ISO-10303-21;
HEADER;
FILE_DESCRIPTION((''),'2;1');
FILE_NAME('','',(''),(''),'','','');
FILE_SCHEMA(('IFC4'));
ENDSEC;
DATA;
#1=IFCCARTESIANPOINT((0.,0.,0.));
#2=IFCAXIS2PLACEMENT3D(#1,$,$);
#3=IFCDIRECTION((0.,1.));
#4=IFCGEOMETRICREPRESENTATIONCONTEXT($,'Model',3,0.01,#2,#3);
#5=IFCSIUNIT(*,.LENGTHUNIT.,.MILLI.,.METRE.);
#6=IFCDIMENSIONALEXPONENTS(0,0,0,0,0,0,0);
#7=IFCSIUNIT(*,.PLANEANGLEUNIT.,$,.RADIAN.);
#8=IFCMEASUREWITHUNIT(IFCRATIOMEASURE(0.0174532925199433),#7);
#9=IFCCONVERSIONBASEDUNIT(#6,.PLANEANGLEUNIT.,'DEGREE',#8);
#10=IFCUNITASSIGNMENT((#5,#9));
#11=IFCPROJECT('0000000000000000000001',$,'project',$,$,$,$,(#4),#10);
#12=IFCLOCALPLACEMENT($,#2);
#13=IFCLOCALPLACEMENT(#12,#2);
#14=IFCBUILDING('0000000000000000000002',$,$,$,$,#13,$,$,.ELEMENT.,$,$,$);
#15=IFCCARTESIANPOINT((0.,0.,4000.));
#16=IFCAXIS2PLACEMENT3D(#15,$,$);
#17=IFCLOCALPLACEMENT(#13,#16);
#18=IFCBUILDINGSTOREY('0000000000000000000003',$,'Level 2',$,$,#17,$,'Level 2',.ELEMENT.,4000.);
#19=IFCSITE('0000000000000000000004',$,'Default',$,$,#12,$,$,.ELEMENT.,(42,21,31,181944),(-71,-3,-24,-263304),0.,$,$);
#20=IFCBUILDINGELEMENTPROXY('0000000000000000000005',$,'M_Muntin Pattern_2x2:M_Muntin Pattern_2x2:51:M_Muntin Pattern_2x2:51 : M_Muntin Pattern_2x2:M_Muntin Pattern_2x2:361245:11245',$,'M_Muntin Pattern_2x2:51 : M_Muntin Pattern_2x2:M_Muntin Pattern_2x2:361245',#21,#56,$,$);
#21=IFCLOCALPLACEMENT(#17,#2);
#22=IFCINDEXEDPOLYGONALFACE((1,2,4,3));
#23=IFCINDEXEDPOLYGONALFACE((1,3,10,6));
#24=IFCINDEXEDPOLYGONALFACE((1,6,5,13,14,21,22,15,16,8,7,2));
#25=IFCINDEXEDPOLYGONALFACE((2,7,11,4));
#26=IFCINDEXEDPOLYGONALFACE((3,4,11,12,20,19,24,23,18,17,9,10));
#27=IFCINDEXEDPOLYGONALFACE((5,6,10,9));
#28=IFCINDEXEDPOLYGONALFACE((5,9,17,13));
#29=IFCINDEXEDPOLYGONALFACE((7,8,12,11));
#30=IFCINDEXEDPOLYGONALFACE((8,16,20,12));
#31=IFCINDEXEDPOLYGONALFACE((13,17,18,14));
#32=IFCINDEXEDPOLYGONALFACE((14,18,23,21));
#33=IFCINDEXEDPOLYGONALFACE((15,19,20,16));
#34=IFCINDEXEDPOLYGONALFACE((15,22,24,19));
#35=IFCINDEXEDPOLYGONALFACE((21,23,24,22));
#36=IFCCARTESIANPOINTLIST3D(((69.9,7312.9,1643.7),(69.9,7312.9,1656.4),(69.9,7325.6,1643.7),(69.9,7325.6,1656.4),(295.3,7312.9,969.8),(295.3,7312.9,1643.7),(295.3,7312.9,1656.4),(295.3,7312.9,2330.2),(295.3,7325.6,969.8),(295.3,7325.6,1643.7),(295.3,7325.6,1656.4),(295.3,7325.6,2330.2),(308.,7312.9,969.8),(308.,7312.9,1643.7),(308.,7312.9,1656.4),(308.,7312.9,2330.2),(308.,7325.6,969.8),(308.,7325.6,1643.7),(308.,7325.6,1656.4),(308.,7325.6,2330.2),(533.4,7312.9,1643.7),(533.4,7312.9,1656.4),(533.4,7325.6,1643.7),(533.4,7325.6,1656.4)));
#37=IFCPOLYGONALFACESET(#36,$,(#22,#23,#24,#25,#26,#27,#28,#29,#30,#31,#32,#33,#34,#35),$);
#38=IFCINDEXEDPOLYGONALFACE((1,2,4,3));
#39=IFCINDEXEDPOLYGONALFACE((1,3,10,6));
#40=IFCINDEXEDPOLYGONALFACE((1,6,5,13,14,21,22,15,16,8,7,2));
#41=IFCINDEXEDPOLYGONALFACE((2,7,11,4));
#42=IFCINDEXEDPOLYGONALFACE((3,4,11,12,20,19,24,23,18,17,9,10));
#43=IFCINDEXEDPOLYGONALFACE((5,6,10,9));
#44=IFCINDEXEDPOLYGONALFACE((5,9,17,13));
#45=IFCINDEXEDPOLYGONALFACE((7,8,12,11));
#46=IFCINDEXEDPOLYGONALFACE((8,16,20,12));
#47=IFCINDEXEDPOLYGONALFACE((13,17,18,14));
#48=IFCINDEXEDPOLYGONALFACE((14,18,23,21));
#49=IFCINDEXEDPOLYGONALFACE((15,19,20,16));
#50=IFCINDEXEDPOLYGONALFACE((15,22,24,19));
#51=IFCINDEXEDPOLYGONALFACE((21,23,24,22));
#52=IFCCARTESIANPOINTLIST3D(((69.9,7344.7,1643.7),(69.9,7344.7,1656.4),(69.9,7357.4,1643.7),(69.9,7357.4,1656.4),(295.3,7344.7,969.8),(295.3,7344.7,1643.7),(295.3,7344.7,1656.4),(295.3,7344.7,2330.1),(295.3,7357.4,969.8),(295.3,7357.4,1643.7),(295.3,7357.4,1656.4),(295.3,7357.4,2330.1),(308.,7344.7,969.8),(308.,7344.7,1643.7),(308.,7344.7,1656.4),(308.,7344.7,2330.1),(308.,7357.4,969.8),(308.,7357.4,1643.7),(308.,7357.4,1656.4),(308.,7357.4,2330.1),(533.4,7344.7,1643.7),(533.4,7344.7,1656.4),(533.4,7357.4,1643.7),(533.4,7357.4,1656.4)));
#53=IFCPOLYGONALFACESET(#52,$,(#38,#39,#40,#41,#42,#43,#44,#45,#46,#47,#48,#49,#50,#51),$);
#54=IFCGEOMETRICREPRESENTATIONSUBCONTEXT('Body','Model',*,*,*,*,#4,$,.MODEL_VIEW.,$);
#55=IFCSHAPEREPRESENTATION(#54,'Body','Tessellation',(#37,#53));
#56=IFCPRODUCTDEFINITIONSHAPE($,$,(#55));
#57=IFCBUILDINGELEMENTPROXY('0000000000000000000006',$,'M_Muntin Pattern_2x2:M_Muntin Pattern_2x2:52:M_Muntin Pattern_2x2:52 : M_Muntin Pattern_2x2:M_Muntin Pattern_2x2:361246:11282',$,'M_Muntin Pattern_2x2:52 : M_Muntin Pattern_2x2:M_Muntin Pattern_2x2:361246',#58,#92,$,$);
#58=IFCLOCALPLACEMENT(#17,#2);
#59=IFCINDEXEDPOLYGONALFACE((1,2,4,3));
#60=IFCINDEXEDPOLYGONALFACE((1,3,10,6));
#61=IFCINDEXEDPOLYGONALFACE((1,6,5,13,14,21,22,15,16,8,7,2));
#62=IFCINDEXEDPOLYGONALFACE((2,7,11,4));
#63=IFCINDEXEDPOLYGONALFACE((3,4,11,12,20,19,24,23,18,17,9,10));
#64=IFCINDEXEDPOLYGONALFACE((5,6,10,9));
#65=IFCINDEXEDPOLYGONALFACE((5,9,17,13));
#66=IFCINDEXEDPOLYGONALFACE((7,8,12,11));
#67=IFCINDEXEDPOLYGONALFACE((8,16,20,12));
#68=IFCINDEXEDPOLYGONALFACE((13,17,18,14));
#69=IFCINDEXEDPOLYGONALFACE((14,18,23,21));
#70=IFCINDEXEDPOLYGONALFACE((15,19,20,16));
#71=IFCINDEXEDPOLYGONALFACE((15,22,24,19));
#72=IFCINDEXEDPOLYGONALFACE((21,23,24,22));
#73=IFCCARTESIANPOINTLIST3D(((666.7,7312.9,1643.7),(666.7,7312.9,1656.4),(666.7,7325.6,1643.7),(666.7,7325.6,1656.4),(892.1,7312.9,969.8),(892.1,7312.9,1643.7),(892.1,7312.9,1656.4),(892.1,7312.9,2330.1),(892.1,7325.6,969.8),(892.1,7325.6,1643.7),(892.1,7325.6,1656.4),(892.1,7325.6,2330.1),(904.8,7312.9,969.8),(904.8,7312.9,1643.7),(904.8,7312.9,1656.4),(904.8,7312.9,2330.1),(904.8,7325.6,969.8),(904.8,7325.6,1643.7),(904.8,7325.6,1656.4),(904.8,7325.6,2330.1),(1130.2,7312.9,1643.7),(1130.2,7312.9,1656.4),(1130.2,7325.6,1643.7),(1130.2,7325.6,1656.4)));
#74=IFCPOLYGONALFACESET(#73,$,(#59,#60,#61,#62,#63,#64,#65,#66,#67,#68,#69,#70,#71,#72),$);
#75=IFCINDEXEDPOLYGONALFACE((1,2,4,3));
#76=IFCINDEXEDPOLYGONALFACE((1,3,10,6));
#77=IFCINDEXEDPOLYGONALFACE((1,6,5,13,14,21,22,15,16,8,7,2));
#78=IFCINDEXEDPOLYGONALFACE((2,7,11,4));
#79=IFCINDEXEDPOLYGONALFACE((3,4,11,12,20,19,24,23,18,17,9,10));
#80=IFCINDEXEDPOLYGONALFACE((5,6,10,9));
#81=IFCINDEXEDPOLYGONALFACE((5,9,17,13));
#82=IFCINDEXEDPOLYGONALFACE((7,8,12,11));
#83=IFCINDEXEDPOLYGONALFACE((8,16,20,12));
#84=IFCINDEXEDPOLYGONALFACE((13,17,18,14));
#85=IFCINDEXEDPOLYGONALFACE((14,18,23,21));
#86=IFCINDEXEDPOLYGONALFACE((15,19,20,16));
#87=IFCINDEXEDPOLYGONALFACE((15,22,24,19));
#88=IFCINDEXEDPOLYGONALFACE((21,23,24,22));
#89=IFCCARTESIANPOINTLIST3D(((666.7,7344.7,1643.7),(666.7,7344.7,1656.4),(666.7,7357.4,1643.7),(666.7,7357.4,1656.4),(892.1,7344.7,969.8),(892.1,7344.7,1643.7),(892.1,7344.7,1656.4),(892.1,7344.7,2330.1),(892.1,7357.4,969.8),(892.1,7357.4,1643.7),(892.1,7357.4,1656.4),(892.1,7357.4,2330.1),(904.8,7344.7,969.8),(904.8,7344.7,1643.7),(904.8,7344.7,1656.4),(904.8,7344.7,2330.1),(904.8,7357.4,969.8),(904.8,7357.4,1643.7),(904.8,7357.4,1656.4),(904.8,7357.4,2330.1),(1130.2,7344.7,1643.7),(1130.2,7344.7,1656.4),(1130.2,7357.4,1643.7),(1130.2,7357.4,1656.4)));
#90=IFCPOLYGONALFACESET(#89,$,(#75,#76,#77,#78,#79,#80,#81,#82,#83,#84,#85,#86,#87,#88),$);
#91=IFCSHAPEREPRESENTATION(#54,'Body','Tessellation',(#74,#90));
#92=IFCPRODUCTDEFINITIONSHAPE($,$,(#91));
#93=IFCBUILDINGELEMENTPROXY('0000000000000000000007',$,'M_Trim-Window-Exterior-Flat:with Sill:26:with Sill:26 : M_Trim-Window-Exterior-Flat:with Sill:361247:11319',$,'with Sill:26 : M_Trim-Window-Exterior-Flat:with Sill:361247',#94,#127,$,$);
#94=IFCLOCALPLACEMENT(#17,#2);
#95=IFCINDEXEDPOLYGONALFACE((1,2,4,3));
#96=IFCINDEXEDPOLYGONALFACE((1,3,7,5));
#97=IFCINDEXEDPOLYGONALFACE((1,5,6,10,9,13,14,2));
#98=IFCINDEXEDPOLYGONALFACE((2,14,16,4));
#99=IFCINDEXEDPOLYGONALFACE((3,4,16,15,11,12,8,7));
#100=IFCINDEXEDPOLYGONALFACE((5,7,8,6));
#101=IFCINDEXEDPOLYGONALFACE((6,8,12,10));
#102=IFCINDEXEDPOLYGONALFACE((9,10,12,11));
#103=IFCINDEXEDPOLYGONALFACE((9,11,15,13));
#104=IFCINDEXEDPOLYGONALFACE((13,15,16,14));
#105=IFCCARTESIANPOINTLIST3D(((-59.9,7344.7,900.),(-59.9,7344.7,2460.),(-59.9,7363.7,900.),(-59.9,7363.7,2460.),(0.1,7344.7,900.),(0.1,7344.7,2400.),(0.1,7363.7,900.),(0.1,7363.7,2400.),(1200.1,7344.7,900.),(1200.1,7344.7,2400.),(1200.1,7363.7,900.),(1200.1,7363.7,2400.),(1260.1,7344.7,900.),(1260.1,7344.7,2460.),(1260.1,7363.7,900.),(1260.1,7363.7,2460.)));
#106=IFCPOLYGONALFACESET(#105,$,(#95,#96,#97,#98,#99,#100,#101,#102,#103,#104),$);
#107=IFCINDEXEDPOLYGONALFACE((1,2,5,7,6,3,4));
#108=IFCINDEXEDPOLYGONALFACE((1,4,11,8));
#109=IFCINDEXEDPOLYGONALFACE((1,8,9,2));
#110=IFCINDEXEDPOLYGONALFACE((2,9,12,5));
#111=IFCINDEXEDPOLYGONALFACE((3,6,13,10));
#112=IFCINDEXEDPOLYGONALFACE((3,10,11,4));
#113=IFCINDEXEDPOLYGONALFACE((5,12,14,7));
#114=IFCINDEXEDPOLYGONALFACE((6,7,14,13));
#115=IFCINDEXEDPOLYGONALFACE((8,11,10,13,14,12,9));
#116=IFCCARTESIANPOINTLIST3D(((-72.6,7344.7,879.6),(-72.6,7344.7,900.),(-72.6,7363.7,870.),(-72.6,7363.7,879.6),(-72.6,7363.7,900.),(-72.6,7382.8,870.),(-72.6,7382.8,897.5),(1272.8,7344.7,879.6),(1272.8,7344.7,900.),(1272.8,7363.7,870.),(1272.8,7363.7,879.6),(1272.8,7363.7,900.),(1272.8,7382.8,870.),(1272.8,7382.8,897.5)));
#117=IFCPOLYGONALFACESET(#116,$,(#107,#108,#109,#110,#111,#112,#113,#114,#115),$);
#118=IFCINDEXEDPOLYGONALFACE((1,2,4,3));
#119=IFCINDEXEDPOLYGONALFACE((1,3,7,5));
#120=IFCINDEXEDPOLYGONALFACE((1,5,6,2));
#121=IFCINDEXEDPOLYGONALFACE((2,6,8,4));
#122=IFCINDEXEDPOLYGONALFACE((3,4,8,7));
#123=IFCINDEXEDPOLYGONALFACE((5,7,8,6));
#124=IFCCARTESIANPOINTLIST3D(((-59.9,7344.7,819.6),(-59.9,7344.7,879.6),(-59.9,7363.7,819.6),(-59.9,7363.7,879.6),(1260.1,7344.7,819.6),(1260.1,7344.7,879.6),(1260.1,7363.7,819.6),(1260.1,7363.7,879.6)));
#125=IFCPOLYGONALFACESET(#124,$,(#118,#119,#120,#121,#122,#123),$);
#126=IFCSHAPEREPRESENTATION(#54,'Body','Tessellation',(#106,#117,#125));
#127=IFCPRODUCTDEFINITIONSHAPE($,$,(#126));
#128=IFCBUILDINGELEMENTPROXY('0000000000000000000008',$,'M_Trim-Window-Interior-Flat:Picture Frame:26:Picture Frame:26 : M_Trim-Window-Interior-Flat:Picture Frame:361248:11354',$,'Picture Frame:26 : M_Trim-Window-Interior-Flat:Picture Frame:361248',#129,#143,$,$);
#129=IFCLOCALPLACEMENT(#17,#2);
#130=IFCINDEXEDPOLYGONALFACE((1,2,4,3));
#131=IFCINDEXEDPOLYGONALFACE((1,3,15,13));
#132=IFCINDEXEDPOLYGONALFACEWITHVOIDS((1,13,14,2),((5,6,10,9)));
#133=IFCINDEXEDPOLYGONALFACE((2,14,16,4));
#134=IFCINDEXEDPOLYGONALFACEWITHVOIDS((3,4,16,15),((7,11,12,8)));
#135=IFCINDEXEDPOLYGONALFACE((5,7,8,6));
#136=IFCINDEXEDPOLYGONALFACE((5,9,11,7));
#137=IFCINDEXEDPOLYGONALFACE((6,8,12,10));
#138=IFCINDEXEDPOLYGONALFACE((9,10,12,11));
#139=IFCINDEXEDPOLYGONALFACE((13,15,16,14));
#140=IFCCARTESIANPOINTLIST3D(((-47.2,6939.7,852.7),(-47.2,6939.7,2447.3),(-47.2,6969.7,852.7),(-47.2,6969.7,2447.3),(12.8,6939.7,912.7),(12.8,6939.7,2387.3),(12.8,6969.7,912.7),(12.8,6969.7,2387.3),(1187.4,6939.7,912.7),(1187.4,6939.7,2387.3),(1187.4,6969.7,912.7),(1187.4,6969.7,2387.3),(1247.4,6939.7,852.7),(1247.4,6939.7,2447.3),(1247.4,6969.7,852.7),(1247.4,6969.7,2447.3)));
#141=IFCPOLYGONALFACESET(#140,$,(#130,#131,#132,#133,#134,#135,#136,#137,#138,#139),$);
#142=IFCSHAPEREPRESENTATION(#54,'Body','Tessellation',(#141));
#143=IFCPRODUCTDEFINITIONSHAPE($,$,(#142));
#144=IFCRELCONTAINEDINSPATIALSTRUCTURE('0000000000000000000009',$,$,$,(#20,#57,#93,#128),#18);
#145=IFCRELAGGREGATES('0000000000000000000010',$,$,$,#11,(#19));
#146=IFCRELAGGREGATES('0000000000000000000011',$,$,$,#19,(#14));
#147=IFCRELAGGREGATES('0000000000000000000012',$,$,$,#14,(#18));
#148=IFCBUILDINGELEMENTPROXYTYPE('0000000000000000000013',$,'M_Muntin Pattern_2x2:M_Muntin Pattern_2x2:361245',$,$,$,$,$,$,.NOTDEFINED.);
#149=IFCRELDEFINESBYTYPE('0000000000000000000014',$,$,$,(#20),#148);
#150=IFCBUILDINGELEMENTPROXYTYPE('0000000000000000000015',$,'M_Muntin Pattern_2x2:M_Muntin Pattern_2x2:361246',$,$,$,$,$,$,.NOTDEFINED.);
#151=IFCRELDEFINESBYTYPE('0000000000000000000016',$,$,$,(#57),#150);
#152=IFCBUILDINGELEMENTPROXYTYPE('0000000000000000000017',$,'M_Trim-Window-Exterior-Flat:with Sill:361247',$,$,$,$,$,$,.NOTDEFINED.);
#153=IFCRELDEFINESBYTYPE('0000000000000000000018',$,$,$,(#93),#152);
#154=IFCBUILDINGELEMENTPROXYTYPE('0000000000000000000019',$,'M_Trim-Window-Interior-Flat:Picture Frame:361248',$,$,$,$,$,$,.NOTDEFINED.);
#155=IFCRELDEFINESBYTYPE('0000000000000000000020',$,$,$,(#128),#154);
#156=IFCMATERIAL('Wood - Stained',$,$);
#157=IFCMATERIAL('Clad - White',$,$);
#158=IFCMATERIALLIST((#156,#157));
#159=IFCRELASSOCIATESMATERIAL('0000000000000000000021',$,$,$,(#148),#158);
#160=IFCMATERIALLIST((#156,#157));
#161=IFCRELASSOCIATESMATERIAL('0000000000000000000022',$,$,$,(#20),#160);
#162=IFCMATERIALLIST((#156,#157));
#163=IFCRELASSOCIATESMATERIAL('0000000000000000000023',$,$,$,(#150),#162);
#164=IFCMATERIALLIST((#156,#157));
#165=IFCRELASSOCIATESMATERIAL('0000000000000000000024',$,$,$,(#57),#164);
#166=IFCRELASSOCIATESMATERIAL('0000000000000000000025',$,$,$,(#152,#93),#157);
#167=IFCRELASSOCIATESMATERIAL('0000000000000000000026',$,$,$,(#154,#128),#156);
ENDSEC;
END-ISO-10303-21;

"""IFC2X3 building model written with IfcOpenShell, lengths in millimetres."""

from ifc_helpers import new_model, entity, si_unit, converted_unit, direction, frame, origin, origin_2d_with_axis, place, context, subcontext, project, spatial, polyline, rectangle, outline, extrude, source, transform, mapped, material, material_list, type_object, type_shapes, element, save


model = new_model("IFC2X3")

# Units and contexts
model_context = context("Model", 3, precision=0.01, world=origin(), true_north=direction((0.0, 1.0)))
body_context = subcontext(model_context, "Body", "Model", "MODEL_VIEW")
ifc_project = project(units=[si_unit("LENGTHUNIT", "METRE", prefix="MILLI"), converted_unit("PLANEANGLEUNIT", "DEGREE", entity("IfcRatioMeasure", 0.0174532925199433), si_unit("PLANEANGLEUNIT", "RADIAN"), dimensions=[0, 0, 0, 0, 0, 0, 0])], contexts=[model_context])

# Site, building, storey
site_placement = place(None, origin())
site = spatial("IfcSite", under=ifc_project, at=site_placement, Name="Default", CompositionType="ELEMENT", RefLatitude=(42, 21, 31, 181944), RefLongitude=(-71, -3, -24, -263304), RefElevation=0.0)
building_placement = place(site_placement, origin())
building = spatial("IfcBuilding", under=site, at=building_placement, CompositionType="ELEMENT")
storey_placement = place(building_placement, frame((0.0, 0.0, 4000.0)))
storey = spatial("IfcBuildingStorey", under=building, at=storey_placement, Name="Level 2", LongName="Level 2", CompositionType="ELEMENT", Elevation=4000.0)

# Building element proxies
ifc_material_1 = material(Name="Wood - Stained")
ifc_material_2 = material(Name="Clad - White")
ifc_material_list_1 = material_list([ifc_material_1, ifc_material_2])
ifc_material_list_2 = material_list([ifc_material_1, ifc_material_2])
building_element_proxy_type_1 = type_object("IfcBuildingElementProxyType", Name="M_Muntin Pattern_2x2:M_Muntin Pattern_2x2:361245", PredefinedType="NOTDEFINED", material=ifc_material_list_2)
shared_shape_1 = source(origin(), body_context, "Body", "SweptSolid", [
    extrude(outline(polyline([(-6.4, -680.2), (6.3, -680.2), (6.3, -6.4), (231.7, -6.4), (231.7, 6.3), (6.3, 6.3), (6.3, 680.2), (-6.4, 680.2), (-6.4, 6.3), (-231.7, 6.3), (-231.7, -6.4), (-6.4, -6.4), (-6.4, -680.2)])), frame((301.6, 7312.9, 5650.0), z_axis=(0.0, 1.0, 0.0), x_axis=(1.0, 0.0, 0.0)), (0.0, 0.0, 1.0), 12.7),
    extrude(outline(polyline([(-6.4, -680.1), (6.3, -680.1), (6.3, -6.4), (231.7, -6.4), (231.7, 6.3), (6.3, 6.3), (6.3, 680.2), (-6.4, 680.2), (-6.4, 6.3), (-231.7, 6.3), (-231.7, -6.4), (-6.4, -6.4), (-6.4, -680.1)])), frame((301.6, 7344.7, 5650.0), z_axis=(0.0, 1.0, 0.0), x_axis=(1.0, 0.0, 0.0)), (0.0, 0.0, 1.0), 12.7),
])
type_shapes(building_element_proxy_type_1, [shared_shape_1])
proxy_1_placement = place(storey_placement, frame((0.0, 0.0, -4000.0)))
element("IfcBuildingElementProxy", 1, at=proxy_1_placement, inside=storey, type_object=building_element_proxy_type_1, material=ifc_material_list_1, Name="M_Muntin Pattern_2x2:M_Muntin Pattern_2x2:51:M_Muntin Pattern_2x2:51 : M_Muntin Pattern_2x2:M_Muntin Pattern_2x2:361245:11245", ObjectType="M_Muntin Pattern_2x2:51 : M_Muntin Pattern_2x2:M_Muntin Pattern_2x2:361245", context=body_context, shape_type="MappedRepresentation", body=[
    mapped(shared_shape_1, transform((0.0, 0.0, 0.0), scale=1.0)),
])
ifc_material_list_3 = material_list([ifc_material_1, ifc_material_2])
ifc_material_list_4 = material_list([ifc_material_1, ifc_material_2])
building_element_proxy_type_2 = type_object("IfcBuildingElementProxyType", Name="M_Muntin Pattern_2x2:M_Muntin Pattern_2x2:361246", PredefinedType="NOTDEFINED", material=ifc_material_list_4)
shared_shape_2 = source(origin(), body_context, "Body", "SweptSolid", [
    extrude(outline(polyline([(-680.1, 6.4), (-680.1, -6.3), (-6.4, -6.3), (-6.4, -231.7), (6.3, -231.7), (6.3, -6.3), (680.2, -6.3), (680.2, 6.4), (6.3, 6.4), (6.3, 231.7), (-6.4, 231.7), (-6.4, 6.4), (-680.1, 6.4)])), frame((898.5, 7312.9, 5650.0), z_axis=(0.0, -1.0, 0.0), x_axis=(0.0, 0.0, -1.0)), (0.0, 0.0, -1.0), 12.7),
    extrude(outline(polyline([(-680.1, 6.4), (-680.1, -6.3), (-6.4, -6.3), (-6.4, -231.7), (6.3, -231.7), (6.3, -6.3), (680.2, -6.3), (680.2, 6.4), (6.3, 6.4), (6.3, 231.7), (-6.4, 231.7), (-6.4, 6.4), (-680.1, 6.4)])), frame((898.5, 7344.7, 5650.0), z_axis=(0.0, -1.0, 0.0), x_axis=(0.0, 0.0, -1.0)), (0.0, 0.0, -1.0), 12.7),
])
type_shapes(building_element_proxy_type_2, [shared_shape_2])
proxy_2_placement = place(storey_placement, frame((0.0, 0.0, -4000.0)))
element("IfcBuildingElementProxy", 2, at=proxy_2_placement, inside=storey, type_object=building_element_proxy_type_2, material=ifc_material_list_3, Name="M_Muntin Pattern_2x2:M_Muntin Pattern_2x2:52:M_Muntin Pattern_2x2:52 : M_Muntin Pattern_2x2:M_Muntin Pattern_2x2:361246:11282", ObjectType="M_Muntin Pattern_2x2:52 : M_Muntin Pattern_2x2:M_Muntin Pattern_2x2:361246", context=body_context, shape_type="MappedRepresentation", body=[
    mapped(shared_shape_2, transform((0.0, 0.0, 0.0), scale=1.0)),
])
building_element_proxy_type_3 = type_object("IfcBuildingElementProxyType", Name="M_Trim-Window-Exterior-Flat:with Sill:361247", PredefinedType="NOTDEFINED", material=ifc_material_2)
shared_shape_3 = source(origin(), body_context, "Body", "SweptSolid", [
    extrude(outline(polyline([(-660.0, -765.0), (-600.0, -765.0), (-600.0, 735.0), (600.0, 735.0), (600.0, -765.0), (660.0, -765.0), (660.0, 795.0), (-660.0, 795.0), (-660.0, -765.0)])), frame((600.1, 7344.7, 5665.0), z_axis=(0.0, 1.0, 0.0), x_axis=(-1.0, 0.0, 0.0)), (0.0, 0.0, 1.0), 19.1),
    extrude(outline(polyline([(0.0, -15.2), (19.0, -15.2), (19.0, 12.3), (0.0, 14.8), (-19.0, 14.8), (-19.0, -5.7), (0.0, -5.7), (0.0, -15.2)])), frame((-72.6, 7363.7, 4885.2), z_axis=(1.0, 0.0, 0.0), x_axis=(0.0, 1.0, 0.0)), (0.0, 0.0, 1.0), 1345.4),
    extrude(rectangle(XDim=19.1, YDim=1320.0, at=origin_2d_with_axis()), frame((600.1, 7354.2, 4819.6), z_axis=(0.0, 0.0, 1.0), x_axis=(0.0, -1.0, 0.0)), (0.0, 0.0, 1.0), 60.0),
])
type_shapes(building_element_proxy_type_3, [shared_shape_3])
proxy_3_placement = place(storey_placement, frame((0.0, 0.0, -4000.0)))
element("IfcBuildingElementProxy", 3, at=proxy_3_placement, inside=storey, type_object=building_element_proxy_type_3, material=ifc_material_2, Name="M_Trim-Window-Exterior-Flat:with Sill:26:with Sill:26 : M_Trim-Window-Exterior-Flat:with Sill:361247:11319", ObjectType="with Sill:26 : M_Trim-Window-Exterior-Flat:with Sill:361247", context=body_context, shape_type="MappedRepresentation", body=[
    mapped(shared_shape_3, transform((0.0, 0.0, 0.0), scale=1.0)),
])
building_element_proxy_type_4 = type_object("IfcBuildingElementProxyType", Name="M_Trim-Window-Interior-Flat:Picture Frame:361248", PredefinedType="NOTDEFINED", material=ifc_material_1)
shared_shape_4 = source(origin(), body_context, "Body", "SweptSolid", [
    extrude(outline(polyline([(-647.3, -797.3), (647.3, -797.3), (647.3, 797.3), (-647.3, 797.3), (-647.3, -797.3)]), holes=[polyline([(587.3, 737.3), (587.3, -737.3), (-587.3, -737.3), (-587.3, 737.3), (587.3, 737.3)])]), frame((600.1, 6939.7, 5650.0), z_axis=(0.0, 1.0, 0.0), x_axis=(1.0, 0.0, 0.0)), (0.0, 0.0, 1.0), 30.0),
])
type_shapes(building_element_proxy_type_4, [shared_shape_4])
proxy_4_placement = place(storey_placement, frame((0.0, 0.0, -4000.0)))
element("IfcBuildingElementProxy", 4, at=proxy_4_placement, inside=storey, type_object=building_element_proxy_type_4, material=ifc_material_1, Name="M_Trim-Window-Interior-Flat:Picture Frame:26:Picture Frame:26 : M_Trim-Window-Interior-Flat:Picture Frame:361248:11354", ObjectType="Picture Frame:26 : M_Trim-Window-Interior-Flat:Picture Frame:361248", context=body_context, shape_type="MappedRepresentation", body=[
    mapped(shared_shape_4, transform((0.0, 0.0, 0.0), scale=1.0)),
])

save(model, "model.ifc")
